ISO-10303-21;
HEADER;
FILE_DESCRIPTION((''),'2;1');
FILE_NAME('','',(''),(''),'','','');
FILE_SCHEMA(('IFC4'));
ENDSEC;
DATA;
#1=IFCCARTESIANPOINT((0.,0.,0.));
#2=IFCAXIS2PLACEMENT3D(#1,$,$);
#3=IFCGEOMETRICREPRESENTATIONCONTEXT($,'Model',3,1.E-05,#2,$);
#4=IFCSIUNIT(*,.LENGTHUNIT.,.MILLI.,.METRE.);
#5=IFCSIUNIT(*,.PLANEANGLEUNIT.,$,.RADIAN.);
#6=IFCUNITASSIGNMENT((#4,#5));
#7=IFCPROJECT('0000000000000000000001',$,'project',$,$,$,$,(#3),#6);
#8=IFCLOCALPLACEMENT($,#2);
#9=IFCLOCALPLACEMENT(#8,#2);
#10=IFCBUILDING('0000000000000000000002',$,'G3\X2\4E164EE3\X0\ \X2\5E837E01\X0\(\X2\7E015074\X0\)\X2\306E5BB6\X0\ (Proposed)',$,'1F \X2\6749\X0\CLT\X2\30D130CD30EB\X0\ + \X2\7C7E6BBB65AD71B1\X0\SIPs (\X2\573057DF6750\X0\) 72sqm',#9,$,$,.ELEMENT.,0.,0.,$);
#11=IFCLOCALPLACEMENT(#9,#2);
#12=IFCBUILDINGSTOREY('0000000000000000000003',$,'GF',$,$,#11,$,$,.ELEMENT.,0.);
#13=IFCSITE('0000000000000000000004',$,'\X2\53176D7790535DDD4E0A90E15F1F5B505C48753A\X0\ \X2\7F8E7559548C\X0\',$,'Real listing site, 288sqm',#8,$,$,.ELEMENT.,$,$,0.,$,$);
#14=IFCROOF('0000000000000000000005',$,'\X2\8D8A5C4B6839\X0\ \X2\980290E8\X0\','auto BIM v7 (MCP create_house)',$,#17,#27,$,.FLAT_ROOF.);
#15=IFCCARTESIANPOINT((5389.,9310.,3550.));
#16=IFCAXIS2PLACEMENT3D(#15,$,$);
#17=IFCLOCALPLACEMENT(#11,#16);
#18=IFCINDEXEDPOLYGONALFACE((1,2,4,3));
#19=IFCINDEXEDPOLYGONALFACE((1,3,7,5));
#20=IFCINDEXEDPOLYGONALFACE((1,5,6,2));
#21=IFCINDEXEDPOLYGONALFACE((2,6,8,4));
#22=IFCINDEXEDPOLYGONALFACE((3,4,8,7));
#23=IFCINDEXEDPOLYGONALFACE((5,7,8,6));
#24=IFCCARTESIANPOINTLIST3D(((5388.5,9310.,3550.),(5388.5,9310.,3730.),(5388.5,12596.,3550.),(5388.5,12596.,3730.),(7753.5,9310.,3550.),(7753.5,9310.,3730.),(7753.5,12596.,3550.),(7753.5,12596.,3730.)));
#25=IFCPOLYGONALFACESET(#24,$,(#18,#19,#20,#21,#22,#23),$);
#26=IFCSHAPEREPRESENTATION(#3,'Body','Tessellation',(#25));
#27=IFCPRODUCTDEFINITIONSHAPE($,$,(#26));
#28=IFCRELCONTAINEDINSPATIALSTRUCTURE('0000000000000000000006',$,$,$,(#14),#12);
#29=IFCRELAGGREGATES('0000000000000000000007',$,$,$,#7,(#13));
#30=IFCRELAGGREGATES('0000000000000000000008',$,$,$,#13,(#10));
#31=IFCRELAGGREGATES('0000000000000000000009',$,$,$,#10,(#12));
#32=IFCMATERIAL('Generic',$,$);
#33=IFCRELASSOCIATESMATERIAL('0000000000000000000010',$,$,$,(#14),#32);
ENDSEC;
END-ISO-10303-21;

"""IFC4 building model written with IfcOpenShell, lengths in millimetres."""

from ifc_helpers import new_model, si_unit, frame, frame_2d, origin, place, context, project, spatial, rectangle, extrude, material, element, save


model = new_model("IFC4")

# Units and contexts
model_context = context("Model", 3, precision=1e-05, world=origin())
ifc_project = project(units=[si_unit("LENGTHUNIT", "METRE", prefix="MILLI"), si_unit("PLANEANGLEUNIT", "RADIAN")], contexts=[model_context])

# Site, building, storey
site_placement = place(None, origin())
site = spatial("IfcSite", under=ifc_project, at=site_placement, Name="北海道川上郡弟子屈町 美留和", ObjectType="Real listing site, 288sqm", CompositionType="ELEMENT", RefElevation=0.0)
building_placement = place(site_placement, origin())
building = spatial("IfcBuilding", under=site, at=building_placement, Name="G3世代 広縁(縁側)の家 (Proposed)", ObjectType="1F 杉CLTパネル + 籾殻断熱SIPs (地域材) 72sqm", CompositionType="ELEMENT", ElevationOfRefHeight=0.0, ElevationOfTerrain=0.0)
storey_placement = place(building_placement, origin())
storey = spatial("IfcBuildingStorey", under=building, at=storey_placement, Name="GF", CompositionType="ELEMENT", Elevation=0.0)

# Shared definitions
ifc_material = material(Name="Generic")

# Roof
roof_1_placement = place(storey_placement, frame((5389.0, 9310.0, 3550.0)))
element("IfcRoof", 1, at=roof_1_placement, inside=storey, material=ifc_material, Name="越屋根 頂部", Description="auto BIM v7 (MCP create_house)", PredefinedType="FLAT_ROOF", context=model_context, shape_type="SweptSolid", body=[
    extrude(rectangle(XDim=2365.0, YDim=3286.0, at=frame_2d((1182.0, 1643.0))), frame((5389.0, 9310.0, 3550.0)), (0.0, 0.0, 1.0), 180.0),
])

save(model, "model.ifc")
